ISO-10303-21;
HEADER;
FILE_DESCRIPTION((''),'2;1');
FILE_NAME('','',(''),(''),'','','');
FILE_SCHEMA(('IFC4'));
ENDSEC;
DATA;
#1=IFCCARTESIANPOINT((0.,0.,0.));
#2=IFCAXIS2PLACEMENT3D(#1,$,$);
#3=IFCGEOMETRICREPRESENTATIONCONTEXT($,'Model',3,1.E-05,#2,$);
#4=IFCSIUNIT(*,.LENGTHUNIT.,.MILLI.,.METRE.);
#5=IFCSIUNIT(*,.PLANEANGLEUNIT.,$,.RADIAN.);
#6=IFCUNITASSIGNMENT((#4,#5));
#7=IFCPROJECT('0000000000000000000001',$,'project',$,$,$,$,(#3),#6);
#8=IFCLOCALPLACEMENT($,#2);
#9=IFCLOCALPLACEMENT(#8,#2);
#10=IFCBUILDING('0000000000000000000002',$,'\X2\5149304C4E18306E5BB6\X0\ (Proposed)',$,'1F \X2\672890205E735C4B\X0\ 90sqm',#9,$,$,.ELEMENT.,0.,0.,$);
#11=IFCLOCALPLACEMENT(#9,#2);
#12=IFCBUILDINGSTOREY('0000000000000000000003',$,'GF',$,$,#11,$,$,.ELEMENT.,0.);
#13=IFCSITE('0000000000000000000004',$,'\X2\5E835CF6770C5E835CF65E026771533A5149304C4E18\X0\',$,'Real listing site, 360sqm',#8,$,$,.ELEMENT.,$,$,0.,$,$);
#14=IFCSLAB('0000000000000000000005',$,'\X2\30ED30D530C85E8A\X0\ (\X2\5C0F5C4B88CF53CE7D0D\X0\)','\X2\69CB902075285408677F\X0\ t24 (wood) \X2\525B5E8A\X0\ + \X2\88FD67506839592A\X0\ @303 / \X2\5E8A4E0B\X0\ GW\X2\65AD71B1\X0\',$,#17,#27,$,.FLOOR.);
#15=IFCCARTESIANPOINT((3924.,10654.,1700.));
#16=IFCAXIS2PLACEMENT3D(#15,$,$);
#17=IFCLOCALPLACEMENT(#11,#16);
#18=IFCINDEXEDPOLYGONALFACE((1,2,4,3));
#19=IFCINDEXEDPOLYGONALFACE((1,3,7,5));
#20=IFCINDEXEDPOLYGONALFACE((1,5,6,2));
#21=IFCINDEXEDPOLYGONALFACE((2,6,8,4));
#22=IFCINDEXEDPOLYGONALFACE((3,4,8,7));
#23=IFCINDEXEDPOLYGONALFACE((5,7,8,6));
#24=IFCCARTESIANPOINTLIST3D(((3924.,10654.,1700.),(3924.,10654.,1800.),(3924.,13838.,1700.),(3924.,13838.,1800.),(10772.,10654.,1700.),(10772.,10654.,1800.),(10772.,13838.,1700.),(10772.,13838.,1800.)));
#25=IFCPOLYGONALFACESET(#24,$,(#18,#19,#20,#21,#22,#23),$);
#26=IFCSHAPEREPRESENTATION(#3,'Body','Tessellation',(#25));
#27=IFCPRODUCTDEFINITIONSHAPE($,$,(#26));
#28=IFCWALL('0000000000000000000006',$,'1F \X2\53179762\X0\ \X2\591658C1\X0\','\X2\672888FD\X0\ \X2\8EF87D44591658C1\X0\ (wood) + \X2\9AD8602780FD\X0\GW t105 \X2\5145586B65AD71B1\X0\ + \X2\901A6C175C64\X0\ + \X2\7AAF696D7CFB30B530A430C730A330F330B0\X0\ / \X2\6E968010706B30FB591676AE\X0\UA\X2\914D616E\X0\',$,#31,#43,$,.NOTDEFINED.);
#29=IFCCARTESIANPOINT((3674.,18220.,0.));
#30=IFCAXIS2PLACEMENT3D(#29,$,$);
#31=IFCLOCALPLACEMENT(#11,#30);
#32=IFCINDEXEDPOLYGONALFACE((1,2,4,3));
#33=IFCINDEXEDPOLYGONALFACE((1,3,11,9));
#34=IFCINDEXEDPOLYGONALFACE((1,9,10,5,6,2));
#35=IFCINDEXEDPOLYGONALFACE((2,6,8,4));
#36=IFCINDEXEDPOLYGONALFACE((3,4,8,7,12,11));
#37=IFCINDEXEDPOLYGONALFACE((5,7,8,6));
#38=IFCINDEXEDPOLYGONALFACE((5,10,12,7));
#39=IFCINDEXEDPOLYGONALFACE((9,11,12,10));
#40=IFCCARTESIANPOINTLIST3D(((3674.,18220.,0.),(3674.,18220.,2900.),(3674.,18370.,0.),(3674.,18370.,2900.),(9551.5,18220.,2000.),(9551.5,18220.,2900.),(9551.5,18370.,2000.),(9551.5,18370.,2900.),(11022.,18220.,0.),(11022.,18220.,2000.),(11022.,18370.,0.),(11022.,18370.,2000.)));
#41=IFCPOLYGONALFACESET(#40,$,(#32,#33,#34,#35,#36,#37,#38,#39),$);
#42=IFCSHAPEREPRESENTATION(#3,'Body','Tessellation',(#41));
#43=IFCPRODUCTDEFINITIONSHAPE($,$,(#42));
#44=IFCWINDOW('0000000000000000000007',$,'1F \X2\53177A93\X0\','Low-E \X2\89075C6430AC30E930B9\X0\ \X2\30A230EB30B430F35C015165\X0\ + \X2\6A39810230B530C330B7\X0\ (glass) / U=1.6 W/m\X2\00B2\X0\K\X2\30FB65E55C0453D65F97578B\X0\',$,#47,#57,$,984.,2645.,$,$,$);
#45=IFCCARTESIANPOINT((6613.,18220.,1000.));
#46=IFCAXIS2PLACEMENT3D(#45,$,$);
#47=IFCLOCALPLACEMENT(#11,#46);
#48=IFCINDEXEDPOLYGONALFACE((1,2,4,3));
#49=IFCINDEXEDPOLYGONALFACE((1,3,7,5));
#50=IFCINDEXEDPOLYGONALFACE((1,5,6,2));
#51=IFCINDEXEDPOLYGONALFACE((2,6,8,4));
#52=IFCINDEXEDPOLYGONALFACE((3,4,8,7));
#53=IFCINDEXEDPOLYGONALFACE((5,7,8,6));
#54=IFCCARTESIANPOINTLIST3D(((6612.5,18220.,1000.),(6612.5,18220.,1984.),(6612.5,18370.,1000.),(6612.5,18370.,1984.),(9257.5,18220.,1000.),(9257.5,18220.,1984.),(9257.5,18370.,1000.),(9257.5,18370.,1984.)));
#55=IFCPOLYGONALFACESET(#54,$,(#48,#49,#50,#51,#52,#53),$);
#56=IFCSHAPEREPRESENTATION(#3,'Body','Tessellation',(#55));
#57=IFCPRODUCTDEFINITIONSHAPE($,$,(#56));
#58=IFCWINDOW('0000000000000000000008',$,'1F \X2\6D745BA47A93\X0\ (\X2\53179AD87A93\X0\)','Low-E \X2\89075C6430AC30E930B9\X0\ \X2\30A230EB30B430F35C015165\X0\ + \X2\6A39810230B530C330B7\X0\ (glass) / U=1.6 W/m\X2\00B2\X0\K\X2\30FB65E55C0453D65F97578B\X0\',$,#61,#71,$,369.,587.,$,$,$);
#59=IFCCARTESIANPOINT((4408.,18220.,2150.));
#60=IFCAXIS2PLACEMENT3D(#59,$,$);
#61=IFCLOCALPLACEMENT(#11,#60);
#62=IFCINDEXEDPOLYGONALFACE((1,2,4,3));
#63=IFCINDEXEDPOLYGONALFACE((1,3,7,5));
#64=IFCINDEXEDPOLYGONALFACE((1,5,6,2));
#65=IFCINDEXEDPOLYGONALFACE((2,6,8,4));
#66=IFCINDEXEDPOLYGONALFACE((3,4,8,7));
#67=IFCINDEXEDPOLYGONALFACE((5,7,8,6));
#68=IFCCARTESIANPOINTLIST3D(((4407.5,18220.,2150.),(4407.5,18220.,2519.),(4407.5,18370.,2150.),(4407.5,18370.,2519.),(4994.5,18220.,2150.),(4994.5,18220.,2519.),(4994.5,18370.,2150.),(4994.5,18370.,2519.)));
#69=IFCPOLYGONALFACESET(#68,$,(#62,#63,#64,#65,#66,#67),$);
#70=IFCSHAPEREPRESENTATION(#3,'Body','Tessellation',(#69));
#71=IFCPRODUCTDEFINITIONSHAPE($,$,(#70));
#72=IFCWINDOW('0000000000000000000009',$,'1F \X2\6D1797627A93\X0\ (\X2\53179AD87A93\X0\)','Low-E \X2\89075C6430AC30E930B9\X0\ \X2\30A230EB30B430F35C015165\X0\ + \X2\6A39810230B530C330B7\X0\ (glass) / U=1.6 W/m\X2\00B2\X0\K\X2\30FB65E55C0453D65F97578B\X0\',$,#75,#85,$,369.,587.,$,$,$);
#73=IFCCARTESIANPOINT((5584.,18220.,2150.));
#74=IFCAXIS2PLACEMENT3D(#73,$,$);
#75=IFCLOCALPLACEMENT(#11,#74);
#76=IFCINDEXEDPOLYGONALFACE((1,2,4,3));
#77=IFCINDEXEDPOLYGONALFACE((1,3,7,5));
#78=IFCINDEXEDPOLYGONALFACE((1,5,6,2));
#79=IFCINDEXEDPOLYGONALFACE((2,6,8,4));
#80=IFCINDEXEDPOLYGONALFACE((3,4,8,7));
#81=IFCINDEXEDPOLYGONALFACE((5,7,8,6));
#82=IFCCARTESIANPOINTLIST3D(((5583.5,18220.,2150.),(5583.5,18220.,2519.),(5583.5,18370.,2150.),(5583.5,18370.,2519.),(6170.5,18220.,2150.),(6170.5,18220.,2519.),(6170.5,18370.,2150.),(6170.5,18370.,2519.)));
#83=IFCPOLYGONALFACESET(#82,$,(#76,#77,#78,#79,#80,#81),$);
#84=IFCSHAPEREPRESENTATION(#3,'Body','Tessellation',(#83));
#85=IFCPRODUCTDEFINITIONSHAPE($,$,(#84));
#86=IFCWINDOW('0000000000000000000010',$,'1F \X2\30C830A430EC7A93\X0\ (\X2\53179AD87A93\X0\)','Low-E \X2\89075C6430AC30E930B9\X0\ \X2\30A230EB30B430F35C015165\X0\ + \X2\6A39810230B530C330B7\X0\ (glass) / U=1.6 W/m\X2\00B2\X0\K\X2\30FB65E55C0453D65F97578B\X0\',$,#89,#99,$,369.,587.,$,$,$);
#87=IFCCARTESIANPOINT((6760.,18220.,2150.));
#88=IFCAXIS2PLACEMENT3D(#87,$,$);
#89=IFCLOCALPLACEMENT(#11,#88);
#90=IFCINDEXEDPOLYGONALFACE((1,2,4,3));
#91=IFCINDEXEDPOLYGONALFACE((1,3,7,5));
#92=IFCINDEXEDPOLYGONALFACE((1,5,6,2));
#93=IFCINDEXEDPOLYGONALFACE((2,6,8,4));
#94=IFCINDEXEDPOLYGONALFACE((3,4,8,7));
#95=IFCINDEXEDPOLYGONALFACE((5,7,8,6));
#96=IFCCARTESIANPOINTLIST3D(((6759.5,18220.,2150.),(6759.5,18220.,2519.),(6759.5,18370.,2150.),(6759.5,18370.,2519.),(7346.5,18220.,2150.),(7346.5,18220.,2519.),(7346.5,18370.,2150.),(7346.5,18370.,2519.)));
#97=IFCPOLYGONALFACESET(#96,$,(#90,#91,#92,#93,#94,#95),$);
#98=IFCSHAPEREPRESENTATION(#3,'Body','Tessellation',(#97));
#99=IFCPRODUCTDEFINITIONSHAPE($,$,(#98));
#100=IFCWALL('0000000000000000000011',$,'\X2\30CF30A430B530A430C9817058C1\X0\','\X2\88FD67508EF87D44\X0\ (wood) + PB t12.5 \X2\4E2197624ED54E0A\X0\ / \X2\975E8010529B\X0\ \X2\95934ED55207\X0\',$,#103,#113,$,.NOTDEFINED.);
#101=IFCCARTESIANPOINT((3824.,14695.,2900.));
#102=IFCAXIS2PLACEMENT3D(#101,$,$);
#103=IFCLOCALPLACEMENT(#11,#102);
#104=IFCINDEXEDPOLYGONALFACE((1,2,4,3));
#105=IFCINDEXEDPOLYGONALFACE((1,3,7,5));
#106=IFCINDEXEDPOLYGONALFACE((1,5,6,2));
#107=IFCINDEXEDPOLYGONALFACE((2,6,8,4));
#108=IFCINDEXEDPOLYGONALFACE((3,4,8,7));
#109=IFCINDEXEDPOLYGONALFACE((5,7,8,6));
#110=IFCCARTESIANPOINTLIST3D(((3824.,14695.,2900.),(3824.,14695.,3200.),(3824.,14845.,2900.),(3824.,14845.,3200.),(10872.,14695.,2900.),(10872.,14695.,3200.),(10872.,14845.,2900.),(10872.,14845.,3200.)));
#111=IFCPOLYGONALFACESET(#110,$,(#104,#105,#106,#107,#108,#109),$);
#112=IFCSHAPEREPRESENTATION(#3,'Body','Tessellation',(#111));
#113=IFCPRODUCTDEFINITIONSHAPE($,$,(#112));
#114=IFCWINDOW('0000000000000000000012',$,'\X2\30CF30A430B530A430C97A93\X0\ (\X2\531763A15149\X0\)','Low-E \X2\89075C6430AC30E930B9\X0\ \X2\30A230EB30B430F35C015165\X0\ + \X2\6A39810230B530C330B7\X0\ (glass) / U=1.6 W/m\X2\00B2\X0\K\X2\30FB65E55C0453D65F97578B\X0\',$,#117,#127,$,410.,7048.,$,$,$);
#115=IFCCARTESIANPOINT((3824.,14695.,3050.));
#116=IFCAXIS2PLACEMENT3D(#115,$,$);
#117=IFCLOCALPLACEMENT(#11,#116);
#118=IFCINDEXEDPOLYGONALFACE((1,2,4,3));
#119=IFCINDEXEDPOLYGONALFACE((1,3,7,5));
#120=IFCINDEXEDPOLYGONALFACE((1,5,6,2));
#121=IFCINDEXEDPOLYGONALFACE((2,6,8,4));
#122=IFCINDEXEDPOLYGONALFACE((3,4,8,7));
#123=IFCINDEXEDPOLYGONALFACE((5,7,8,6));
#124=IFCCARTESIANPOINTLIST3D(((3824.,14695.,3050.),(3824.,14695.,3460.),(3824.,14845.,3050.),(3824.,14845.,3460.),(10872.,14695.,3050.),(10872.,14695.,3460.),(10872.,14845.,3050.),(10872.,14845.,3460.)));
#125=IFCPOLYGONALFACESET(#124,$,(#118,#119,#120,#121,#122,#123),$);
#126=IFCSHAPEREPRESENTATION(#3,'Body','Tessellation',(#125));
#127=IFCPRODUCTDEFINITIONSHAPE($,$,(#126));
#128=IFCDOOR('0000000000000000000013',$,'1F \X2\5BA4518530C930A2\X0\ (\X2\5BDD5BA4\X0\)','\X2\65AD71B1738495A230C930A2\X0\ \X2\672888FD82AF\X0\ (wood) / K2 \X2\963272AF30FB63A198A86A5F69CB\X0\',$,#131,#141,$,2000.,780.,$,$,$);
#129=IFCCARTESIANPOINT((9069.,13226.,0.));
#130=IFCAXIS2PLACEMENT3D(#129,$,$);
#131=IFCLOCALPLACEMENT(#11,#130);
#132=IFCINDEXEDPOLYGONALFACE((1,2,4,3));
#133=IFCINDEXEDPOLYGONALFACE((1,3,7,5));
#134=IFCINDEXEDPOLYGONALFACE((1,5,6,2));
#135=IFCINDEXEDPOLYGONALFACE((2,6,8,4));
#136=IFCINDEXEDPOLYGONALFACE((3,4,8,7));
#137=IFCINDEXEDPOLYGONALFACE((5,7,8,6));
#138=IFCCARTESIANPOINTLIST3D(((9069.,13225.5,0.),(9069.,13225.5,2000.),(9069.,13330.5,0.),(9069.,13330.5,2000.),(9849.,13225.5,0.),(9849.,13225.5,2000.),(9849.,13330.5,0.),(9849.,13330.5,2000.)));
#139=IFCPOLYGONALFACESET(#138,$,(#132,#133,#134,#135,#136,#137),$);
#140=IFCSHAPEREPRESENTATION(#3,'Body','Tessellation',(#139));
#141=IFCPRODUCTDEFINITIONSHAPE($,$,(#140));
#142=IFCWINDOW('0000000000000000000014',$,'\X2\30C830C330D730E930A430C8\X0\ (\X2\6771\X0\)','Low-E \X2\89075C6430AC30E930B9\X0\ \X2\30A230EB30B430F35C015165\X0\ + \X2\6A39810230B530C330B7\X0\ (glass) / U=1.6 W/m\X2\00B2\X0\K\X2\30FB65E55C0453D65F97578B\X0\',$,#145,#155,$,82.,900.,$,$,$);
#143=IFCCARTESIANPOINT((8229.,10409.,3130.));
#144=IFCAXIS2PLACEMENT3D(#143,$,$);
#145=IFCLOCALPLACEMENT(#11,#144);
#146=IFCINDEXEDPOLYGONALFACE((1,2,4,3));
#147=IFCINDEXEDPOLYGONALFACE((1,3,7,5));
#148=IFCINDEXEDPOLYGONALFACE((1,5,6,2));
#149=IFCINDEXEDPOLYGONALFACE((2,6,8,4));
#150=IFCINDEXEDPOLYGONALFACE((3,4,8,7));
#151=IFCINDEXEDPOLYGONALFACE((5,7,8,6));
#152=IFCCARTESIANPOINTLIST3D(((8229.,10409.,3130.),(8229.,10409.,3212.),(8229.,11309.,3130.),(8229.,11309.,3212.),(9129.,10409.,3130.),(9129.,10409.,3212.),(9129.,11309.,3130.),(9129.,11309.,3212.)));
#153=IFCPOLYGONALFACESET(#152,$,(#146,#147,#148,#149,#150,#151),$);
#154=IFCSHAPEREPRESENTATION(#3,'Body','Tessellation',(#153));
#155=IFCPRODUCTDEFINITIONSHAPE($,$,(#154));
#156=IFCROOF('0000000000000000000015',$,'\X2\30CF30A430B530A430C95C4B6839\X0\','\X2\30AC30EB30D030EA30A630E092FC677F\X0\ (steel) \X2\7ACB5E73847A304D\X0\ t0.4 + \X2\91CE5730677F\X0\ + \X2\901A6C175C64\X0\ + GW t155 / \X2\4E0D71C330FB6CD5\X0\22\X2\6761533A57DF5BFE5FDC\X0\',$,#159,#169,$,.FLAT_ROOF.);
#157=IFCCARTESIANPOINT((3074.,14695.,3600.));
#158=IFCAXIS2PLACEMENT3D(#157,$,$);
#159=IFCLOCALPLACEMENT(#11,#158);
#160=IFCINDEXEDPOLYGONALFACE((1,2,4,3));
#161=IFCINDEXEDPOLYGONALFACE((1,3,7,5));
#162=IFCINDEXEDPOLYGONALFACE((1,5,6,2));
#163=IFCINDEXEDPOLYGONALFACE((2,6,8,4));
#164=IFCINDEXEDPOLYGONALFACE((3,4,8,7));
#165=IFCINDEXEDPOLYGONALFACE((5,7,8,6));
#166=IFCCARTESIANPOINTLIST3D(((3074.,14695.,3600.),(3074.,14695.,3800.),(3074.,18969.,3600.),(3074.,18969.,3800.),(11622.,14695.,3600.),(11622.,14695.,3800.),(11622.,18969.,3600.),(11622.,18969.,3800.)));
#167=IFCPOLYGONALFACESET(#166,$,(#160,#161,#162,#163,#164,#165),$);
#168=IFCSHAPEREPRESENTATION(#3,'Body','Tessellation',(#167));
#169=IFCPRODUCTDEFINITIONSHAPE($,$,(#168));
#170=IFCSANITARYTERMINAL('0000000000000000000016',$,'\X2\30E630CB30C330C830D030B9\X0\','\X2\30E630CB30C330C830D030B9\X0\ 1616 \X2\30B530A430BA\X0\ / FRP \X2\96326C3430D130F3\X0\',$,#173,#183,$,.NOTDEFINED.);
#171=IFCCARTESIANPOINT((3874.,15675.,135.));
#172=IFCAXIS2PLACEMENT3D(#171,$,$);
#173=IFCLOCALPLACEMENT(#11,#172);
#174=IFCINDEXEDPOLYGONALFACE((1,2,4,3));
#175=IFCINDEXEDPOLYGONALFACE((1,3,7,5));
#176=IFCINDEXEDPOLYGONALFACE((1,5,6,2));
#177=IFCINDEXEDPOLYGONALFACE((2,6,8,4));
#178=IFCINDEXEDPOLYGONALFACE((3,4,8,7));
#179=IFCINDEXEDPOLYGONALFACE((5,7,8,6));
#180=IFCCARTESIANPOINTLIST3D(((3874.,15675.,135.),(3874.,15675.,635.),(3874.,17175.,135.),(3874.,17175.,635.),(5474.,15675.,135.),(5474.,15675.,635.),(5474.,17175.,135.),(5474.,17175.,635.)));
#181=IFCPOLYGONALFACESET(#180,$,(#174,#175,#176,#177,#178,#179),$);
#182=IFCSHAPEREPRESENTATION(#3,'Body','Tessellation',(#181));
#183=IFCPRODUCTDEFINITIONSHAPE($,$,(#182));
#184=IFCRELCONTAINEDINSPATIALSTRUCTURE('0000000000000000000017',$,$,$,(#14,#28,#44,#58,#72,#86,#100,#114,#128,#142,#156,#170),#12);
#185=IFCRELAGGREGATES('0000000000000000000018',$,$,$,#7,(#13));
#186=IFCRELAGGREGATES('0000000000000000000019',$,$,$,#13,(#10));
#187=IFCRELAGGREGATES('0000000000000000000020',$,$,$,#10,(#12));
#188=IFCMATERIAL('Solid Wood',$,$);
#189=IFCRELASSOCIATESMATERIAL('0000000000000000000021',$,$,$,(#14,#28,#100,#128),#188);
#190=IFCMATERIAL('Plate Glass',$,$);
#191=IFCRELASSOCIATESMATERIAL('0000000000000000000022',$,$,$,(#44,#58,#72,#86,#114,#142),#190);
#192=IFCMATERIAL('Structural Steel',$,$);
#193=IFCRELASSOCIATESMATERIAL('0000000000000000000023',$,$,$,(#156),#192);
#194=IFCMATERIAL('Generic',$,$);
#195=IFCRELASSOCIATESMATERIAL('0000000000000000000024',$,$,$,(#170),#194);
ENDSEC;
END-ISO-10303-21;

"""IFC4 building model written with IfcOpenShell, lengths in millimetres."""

from ifc_helpers import new_model, si_unit, frame, frame_2d, origin, place, context, project, spatial, rectangle, extrude, material, element, fill, save


model = new_model("IFC4")

# Units and contexts
model_context = context("Model", 3, precision=1e-05, world=origin())
ifc_project = project(units=[si_unit("LENGTHUNIT", "METRE", prefix="MILLI"), si_unit("PLANEANGLEUNIT", "RADIAN")], contexts=[model_context])

# Site, building, storey
site_placement = place(None, origin())
site = spatial("IfcSite", under=ifc_project, at=site_placement, Name="広島県広島市東区光が丘", ObjectType="Real listing site, 360sqm", CompositionType="ELEMENT", RefElevation=0.0)
building_placement = place(site_placement, origin())
building = spatial("IfcBuilding", under=site, at=building_placement, Name="光が丘の家 (Proposed)", ObjectType="1F 木造平屋 90sqm", CompositionType="ELEMENT", ElevationOfRefHeight=0.0, ElevationOfTerrain=0.0)
storey_placement = place(building_placement, origin())
storey = spatial("IfcBuildingStorey", under=building, at=storey_placement, Name="GF", CompositionType="ELEMENT", Elevation=0.0)

# Slab
ifc_material_1 = material(Name="Solid Wood")
slab_placement = place(storey_placement, frame((3924.0, 10654.0, 1700.0)))
element("IfcSlab", 1, at=slab_placement, inside=storey, material=ifc_material_1, Name="ロフト床 (小屋裏収納)", Description="構造用合板 t24 (wood) 剛床 + 製材根太 @303 / 床下 GW断熱", PredefinedType="FLOOR", context=model_context, shape_type="SweptSolid", body=[
    extrude(rectangle(XDim=6848.0, YDim=3184.0, at=frame_2d((3424.0, 1592.0))), frame((3924.0, 10654.0, 1700.0)), (0.0, 0.0, 1.0), 100.0),
])

# Wall, openings, windows
wall_1_placement = place(storey_placement, frame((3674.0, 18220.0, 0.0)))
wall_1 = element("IfcWall", 2, at=wall_1_placement, inside=storey, material=ifc_material_1, Name="1F 北面 外壁", Description="木製 軸組外壁 (wood) + 高性能GW t105 充填断熱 + 通気層 + 窯業系サイディング / 準耐火・外皮UA配慮", PredefinedType="NOTDEFINED", context=model_context, shape_type="SweptSolid", body=[
    extrude(rectangle(XDim=7348.0, YDim=150.0, at=frame_2d((3674.0, 75.0))), frame((3674.0, 18220.0, 0.0)), (0.0, 0.0, 1.0), 2900.0),
])
opening_1_placement = place(storey_placement, frame((6613.0, 18220.0, 1000.0)))
opening_1 = element("IfcOpeningElement", 3, at=opening_1_placement, cuts=wall_1, PredefinedType="NOTDEFINED", context=model_context, shape_type="SweptSolid", body=[
    extrude(rectangle(XDim=2645.0, YDim=150.0, at=frame_2d((1322.0, 75.0))), frame((6613.0, 18220.0, 1000.0)), (0.0, 0.0, 1.0), 984.0),
])
opening_2_placement = place(storey_placement, frame((4408.0, 18220.0, 2150.0)))
opening_2 = element("IfcOpeningElement", 4, at=opening_2_placement, cuts=wall_1, PredefinedType="NOTDEFINED", context=model_context, shape_type="SweptSolid", body=[
    extrude(rectangle(XDim=587.0, YDim=150.0, at=frame_2d((293.0, 75.0))), frame((4408.0, 18220.0, 2150.0)), (0.0, 0.0, 1.0), 369.0),
])
opening_3_placement = place(storey_placement, frame((5584.0, 18220.0, 2150.0)))
opening_3 = element("IfcOpeningElement", 5, at=opening_3_placement, cuts=wall_1, PredefinedType="NOTDEFINED", context=model_context, shape_type="SweptSolid", body=[
    extrude(rectangle(XDim=587.0, YDim=150.0, at=frame_2d((293.0, 75.0))), frame((5584.0, 18220.0, 2150.0)), (0.0, 0.0, 1.0), 369.0),
])
opening_4_placement = place(storey_placement, frame((6760.0, 18220.0, 2150.0)))
opening_4 = element("IfcOpeningElement", 6, at=opening_4_placement, cuts=wall_1, PredefinedType="NOTDEFINED", context=model_context, shape_type="SweptSolid", body=[
    extrude(rectangle(XDim=587.0, YDim=150.0, at=frame_2d((293.0, 75.0))), frame((6760.0, 18220.0, 2150.0)), (0.0, 0.0, 1.0), 369.0),
])
ifc_material_2 = material(Name="Plate Glass")
window_1_placement = place(storey_placement, frame((6613.0, 18220.0, 1000.0)))
window_1 = element("IfcWindow", 7, at=window_1_placement, inside=storey, material=ifc_material_2, Name="1F 北窓", Description="Low-E 複層ガラス アルゴン封入 + 樹脂サッシ (glass) / U=1.6 W/m²K・日射取得型", OverallHeight=984.0, OverallWidth=2645.0, context=model_context, shape_type="SweptSolid", body=[
    extrude(rectangle(XDim=2645.0, YDim=150.0, at=frame_2d((1322.0, 75.0))), frame((6613.0, 18220.0, 1000.0)), (0.0, 0.0, 1.0), 984.0),
])
fill(opening_1, window_1)
window_2_placement = place(storey_placement, frame((4408.0, 18220.0, 2150.0)))
window_2 = element("IfcWindow", 8, at=window_2_placement, inside=storey, material=ifc_material_2, Name="1F 浴室窓 (北高窓)", Description="Low-E 複層ガラス アルゴン封入 + 樹脂サッシ (glass) / U=1.6 W/m²K・日射取得型", OverallHeight=369.0, OverallWidth=587.0, context=model_context, shape_type="SweptSolid", body=[
    extrude(rectangle(XDim=587.0, YDim=150.0, at=frame_2d((293.0, 75.0))), frame((4408.0, 18220.0, 2150.0)), (0.0, 0.0, 1.0), 369.0),
])
fill(opening_2, window_2)
window_3_placement = place(storey_placement, frame((5584.0, 18220.0, 2150.0)))
window_3 = element("IfcWindow", 9, at=window_3_placement, inside=storey, material=ifc_material_2, Name="1F 洗面窓 (北高窓)", Description="Low-E 複層ガラス アルゴン封入 + 樹脂サッシ (glass) / U=1.6 W/m²K・日射取得型", OverallHeight=369.0, OverallWidth=587.0, context=model_context, shape_type="SweptSolid", body=[
    extrude(rectangle(XDim=587.0, YDim=150.0, at=frame_2d((293.0, 75.0))), frame((5584.0, 18220.0, 2150.0)), (0.0, 0.0, 1.0), 369.0),
])
fill(opening_3, window_3)
window_4_placement = place(storey_placement, frame((6760.0, 18220.0, 2150.0)))
window_4 = element("IfcWindow", 10, at=window_4_placement, inside=storey, material=ifc_material_2, Name="1F トイレ窓 (北高窓)", Description="Low-E 複層ガラス アルゴン封入 + 樹脂サッシ (glass) / U=1.6 W/m²K・日射取得型", OverallHeight=369.0, OverallWidth=587.0, context=model_context, shape_type="SweptSolid", body=[
    extrude(rectangle(XDim=587.0, YDim=150.0, at=frame_2d((293.0, 75.0))), frame((6760.0, 18220.0, 2150.0)), (0.0, 0.0, 1.0), 369.0),
])
fill(opening_4, window_4)

# Wall, opening, window
wall_2_placement = place(storey_placement, frame((3824.0, 14695.0, 2900.0)))
wall_2 = element("IfcWall", 11, at=wall_2_placement, inside=storey, material=ifc_material_1, Name="ハイサイド腰壁", Description="製材軸組 (wood) + PB t12.5 両面仕上 / 非耐力 間仕切", PredefinedType="NOTDEFINED", context=model_context, shape_type="SweptSolid", body=[
    extrude(rectangle(XDim=7048.0, YDim=150.0, at=frame_2d((3524.0, 75.0))), frame((3824.0, 14695.0, 2900.0)), (0.0, 0.0, 1.0), 700.0),
])
opening_5_placement = place(storey_placement, frame((3824.0, 14695.0, 3050.0)))
opening_5 = element("IfcOpeningElement", 12, at=opening_5_placement, cuts=wall_2, PredefinedType="NOTDEFINED", context=model_context, shape_type="SweptSolid", body=[
    extrude(rectangle(XDim=7048.0, YDim=150.0, at=frame_2d((3524.0, 75.0))), frame((3824.0, 14695.0, 3050.0)), (0.0, 0.0, 1.0), 410.0),
])
window_5_placement = place(storey_placement, frame((3824.0, 14695.0, 3050.0)))
window_5 = element("IfcWindow", 13, at=window_5_placement, inside=storey, material=ifc_material_2, Name="ハイサイド窓 (北採光)", Description="Low-E 複層ガラス アルゴン封入 + 樹脂サッシ (glass) / U=1.6 W/m²K・日射取得型", OverallHeight=410.0, OverallWidth=7048.0, context=model_context, shape_type="SweptSolid", body=[
    extrude(rectangle(XDim=7048.0, YDim=150.0, at=frame_2d((3524.0, 75.0))), frame((3824.0, 14695.0, 3050.0)), (0.0, 0.0, 1.0), 410.0),
])
fill(opening_5, window_5)

# Door
door_1_placement = place(storey_placement, frame((9069.0, 13226.0, 0.0)))
element("IfcDoor", 14, at=door_1_placement, inside=storey, material=ifc_material_1, Name="1F 室内ドア (寝室)", Description="断熱玄関ドア 木製芯 (wood) / K2 防犯・採風機構", OverallHeight=2000.0, OverallWidth=780.0, context=model_context, shape_type="SweptSolid", body=[
    extrude(rectangle(XDim=780.0, YDim=105.0, at=frame_2d((390.0, 52.0))), frame((9069.0, 13226.0, 0.0)), (0.0, 0.0, 1.0), 2000.0),
])

# Window
window_6_placement = place(storey_placement, frame((8229.0, 10409.0, 3130.0)))
element("IfcWindow", 15, at=window_6_placement, inside=storey, material=ifc_material_2, Name="トップライト (東)", Description="Low-E 複層ガラス アルゴン封入 + 樹脂サッシ (glass) / U=1.6 W/m²K・日射取得型", OverallHeight=82.0, OverallWidth=900.0, context=model_context, shape_type="SweptSolid", body=[
    extrude(rectangle(XDim=900.0, YDim=900.0, at=frame_2d((450.0, 450.0))), frame((8229.0, 10409.0, 3130.0)), (0.0, 0.0, 1.0), 82.0),
])

# Roof
ifc_material_3 = material(Name="Structural Steel")
roof_placement = place(storey_placement, frame((3074.0, 14695.0, 3600.0)))
element("IfcRoof", 16, at=roof_placement, inside=storey, material=ifc_material_3, Name="ハイサイド屋根", Description="ガルバリウム鋼板 (steel) 立平葺き t0.4 + 野地板 + 通気層 + GW t155 / 不燃・法22条区域対応", PredefinedType="FLAT_ROOF", context=model_context, shape_type="SweptSolid", body=[
    extrude(rectangle(XDim=8548.0, YDim=4274.0, at=frame_2d((4274.0, 2137.0))), frame((3074.0, 14695.0, 3600.0)), (0.0, 0.0, 1.0), 200.0),
])

# Sanitary terminal
ifc_material_4 = material(Name="Generic")
sanitary_terminal_1_placement = place(storey_placement, frame((3874.0, 15675.0, 135.0)))
element("IfcSanitaryTerminal", 17, at=sanitary_terminal_1_placement, inside=storey, material=ifc_material_4, Name="ユニットバス", Description="ユニットバス 1616 サイズ / FRP 防水パン", PredefinedType="NOTDEFINED", context=model_context, shape_type="SweptSolid", body=[
    extrude(rectangle(XDim=1600.0, YDim=1500.0, at=frame_2d((800.0, 750.0))), frame((3874.0, 15675.0, 135.0)), (0.0, 0.0, 1.0), 500.0),
])

save(model, "model.ifc")
